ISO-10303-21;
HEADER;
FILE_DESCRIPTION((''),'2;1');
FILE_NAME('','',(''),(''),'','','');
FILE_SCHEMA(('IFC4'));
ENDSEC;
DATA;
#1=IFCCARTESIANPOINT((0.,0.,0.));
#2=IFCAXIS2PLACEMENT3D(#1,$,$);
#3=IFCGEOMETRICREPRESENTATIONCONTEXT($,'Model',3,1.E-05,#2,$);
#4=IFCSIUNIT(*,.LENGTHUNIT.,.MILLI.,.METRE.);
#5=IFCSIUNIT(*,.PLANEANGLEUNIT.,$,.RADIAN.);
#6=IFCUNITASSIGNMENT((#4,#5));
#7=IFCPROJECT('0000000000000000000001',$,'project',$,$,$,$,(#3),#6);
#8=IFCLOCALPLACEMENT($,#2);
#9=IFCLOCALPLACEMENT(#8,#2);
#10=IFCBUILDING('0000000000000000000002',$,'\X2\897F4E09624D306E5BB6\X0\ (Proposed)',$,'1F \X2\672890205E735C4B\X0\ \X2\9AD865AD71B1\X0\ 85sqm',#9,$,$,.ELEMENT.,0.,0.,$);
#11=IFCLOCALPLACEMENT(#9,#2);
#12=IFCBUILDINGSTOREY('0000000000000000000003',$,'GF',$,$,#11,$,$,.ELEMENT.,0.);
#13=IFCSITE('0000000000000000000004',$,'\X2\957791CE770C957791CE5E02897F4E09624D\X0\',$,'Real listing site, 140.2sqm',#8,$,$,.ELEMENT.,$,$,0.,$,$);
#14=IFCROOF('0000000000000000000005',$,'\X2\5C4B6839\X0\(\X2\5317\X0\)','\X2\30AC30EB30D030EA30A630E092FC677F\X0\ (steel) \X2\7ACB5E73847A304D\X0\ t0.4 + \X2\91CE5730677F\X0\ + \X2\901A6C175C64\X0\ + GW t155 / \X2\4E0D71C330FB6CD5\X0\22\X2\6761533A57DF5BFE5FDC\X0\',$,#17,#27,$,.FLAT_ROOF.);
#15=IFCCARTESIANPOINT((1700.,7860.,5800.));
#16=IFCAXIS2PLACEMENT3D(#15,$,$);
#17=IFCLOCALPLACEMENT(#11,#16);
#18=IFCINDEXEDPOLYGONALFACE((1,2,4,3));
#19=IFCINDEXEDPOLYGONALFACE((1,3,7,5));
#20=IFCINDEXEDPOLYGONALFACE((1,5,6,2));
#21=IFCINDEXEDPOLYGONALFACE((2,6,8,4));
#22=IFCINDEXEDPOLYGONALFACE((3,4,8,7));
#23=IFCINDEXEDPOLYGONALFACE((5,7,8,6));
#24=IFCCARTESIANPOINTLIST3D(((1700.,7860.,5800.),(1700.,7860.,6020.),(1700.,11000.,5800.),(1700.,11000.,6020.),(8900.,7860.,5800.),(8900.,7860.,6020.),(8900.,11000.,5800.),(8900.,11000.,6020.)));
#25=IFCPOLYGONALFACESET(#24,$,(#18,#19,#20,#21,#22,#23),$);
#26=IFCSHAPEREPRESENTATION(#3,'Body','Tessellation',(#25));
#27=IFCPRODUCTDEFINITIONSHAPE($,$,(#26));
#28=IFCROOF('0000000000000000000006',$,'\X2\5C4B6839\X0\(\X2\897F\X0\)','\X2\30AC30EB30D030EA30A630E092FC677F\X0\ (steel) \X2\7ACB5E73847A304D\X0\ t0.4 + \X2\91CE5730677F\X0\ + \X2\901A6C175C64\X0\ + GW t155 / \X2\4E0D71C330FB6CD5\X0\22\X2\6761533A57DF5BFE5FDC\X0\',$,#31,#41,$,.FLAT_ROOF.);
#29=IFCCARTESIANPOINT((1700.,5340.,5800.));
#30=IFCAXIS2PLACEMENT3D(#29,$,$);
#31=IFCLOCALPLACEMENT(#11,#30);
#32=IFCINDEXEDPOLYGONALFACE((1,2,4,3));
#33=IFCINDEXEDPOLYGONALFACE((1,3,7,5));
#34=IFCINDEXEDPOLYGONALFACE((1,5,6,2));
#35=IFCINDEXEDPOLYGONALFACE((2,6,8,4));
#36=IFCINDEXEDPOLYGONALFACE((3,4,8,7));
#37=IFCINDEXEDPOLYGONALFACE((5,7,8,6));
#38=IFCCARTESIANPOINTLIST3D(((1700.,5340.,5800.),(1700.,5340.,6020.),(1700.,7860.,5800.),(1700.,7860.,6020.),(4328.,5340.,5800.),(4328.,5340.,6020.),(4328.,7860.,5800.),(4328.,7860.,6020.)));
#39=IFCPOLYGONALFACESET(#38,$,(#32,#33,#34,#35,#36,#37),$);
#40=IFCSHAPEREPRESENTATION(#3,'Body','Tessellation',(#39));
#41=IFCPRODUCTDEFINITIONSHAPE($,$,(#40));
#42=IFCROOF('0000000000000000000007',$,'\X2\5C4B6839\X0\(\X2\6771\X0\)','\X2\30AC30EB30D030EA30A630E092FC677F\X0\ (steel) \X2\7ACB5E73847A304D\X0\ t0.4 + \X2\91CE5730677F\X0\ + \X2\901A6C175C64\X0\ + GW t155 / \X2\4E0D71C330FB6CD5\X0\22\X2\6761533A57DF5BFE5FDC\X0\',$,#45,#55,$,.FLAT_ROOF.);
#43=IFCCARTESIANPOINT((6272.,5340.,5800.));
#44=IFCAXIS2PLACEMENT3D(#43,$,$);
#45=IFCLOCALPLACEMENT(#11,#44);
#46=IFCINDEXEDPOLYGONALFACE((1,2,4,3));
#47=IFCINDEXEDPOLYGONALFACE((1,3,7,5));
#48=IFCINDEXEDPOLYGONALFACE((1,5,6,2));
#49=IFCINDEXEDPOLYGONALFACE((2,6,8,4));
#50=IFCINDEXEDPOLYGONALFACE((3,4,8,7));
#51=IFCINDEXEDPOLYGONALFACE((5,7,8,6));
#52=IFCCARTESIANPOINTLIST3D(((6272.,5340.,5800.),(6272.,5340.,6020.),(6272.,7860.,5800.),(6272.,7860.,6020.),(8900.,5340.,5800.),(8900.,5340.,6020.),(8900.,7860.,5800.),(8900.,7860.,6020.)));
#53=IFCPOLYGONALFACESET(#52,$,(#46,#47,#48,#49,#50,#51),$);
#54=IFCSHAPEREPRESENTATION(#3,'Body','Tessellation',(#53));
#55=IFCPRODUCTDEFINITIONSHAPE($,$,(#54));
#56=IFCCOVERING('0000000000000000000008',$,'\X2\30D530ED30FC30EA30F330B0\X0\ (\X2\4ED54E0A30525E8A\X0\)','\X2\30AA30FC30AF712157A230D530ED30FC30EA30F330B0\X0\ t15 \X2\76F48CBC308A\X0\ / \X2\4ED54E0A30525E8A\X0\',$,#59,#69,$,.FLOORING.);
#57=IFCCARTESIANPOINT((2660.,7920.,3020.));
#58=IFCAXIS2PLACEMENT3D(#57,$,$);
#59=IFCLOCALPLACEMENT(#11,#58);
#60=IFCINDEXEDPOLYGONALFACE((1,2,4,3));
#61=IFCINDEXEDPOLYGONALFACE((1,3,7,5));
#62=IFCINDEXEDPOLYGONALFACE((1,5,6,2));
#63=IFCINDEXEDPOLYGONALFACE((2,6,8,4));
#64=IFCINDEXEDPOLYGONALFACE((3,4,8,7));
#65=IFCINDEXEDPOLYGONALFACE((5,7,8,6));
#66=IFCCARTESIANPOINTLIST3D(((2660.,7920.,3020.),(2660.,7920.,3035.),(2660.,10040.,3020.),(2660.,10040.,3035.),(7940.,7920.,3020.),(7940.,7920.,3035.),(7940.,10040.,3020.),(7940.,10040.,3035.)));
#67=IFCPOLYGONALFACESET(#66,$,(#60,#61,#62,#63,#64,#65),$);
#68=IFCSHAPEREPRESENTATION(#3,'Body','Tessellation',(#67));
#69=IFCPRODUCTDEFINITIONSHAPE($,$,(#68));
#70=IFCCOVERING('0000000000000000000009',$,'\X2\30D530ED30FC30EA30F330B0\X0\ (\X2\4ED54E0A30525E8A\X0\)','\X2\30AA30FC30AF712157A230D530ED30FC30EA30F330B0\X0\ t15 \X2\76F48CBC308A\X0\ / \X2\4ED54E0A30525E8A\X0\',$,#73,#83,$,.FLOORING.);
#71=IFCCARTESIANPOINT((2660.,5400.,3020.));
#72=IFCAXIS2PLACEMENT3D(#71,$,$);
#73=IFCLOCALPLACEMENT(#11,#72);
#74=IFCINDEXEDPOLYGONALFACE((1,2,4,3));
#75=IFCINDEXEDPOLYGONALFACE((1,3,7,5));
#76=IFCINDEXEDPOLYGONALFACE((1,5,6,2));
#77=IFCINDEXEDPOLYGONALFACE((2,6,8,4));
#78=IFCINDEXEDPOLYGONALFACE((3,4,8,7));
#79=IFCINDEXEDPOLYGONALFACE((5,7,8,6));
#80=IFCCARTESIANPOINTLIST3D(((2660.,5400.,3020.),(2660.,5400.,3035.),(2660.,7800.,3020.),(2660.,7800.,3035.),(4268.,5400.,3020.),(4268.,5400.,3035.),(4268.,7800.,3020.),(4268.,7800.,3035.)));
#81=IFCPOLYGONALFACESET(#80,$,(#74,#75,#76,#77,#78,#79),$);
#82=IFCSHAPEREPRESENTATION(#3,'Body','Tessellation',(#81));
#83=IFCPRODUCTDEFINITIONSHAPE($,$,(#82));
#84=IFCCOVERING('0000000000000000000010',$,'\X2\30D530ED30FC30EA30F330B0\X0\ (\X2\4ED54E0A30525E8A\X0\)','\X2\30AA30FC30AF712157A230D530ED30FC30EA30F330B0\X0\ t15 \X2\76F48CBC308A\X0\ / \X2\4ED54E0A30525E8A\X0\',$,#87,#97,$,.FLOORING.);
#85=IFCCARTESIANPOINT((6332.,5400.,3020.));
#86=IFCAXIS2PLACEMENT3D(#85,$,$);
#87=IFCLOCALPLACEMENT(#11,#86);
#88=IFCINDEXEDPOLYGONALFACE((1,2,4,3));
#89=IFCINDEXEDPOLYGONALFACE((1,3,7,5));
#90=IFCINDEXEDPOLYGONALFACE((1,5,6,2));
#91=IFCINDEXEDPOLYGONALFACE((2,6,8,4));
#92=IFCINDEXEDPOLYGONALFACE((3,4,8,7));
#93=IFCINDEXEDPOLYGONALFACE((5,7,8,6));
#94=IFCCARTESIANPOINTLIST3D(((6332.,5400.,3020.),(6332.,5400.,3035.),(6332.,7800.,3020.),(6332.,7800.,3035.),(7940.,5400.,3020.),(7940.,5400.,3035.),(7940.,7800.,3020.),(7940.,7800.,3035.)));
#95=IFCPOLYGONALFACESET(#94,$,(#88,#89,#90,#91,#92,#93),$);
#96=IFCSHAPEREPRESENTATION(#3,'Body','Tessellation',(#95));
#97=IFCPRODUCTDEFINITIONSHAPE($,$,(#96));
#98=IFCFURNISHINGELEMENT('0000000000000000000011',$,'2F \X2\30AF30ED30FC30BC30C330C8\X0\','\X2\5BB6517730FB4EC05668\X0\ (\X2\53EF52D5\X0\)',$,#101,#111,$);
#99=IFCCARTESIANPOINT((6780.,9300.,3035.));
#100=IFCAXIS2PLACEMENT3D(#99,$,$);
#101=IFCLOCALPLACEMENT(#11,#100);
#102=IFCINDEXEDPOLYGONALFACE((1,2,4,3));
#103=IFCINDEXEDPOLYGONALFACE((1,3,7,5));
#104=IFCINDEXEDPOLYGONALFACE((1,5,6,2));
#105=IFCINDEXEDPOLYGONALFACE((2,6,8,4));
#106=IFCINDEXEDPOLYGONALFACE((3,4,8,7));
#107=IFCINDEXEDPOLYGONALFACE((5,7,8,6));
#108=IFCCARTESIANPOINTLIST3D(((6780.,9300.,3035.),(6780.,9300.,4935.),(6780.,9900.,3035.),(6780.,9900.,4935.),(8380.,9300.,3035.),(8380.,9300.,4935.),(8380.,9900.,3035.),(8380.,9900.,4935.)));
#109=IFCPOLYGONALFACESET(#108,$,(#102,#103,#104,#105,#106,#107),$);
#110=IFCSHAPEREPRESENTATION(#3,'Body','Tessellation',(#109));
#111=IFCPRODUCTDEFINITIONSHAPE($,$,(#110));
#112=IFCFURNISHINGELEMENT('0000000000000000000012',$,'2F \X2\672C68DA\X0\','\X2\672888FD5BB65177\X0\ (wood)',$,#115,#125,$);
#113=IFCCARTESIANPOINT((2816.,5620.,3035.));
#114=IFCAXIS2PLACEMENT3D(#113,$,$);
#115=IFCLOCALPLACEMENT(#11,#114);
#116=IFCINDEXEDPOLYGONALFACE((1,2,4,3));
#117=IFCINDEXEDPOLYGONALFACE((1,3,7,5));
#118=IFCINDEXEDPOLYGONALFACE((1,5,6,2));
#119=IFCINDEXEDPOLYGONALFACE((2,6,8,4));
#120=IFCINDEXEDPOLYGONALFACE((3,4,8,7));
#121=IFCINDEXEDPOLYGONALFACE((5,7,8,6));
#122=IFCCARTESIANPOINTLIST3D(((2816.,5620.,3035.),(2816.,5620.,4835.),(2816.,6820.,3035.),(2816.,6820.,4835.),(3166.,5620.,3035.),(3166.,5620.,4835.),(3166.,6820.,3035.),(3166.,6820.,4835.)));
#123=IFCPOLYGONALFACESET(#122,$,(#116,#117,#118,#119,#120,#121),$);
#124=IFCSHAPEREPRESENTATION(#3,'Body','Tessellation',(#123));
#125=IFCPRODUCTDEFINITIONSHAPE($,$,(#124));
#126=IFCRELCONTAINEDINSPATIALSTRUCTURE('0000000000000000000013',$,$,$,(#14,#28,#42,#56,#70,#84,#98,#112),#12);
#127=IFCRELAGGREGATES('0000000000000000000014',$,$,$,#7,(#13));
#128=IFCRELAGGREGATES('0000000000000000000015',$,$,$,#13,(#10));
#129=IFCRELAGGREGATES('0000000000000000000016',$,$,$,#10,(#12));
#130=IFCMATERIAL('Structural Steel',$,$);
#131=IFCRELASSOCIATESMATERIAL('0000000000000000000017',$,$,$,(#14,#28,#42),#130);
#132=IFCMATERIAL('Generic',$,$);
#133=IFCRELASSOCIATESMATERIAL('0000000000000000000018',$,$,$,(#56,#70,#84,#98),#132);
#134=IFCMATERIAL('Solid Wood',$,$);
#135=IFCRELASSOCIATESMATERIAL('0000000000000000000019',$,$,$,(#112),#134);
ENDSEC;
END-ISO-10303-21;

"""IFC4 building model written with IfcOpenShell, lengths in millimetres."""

from ifc_helpers import new_model, si_unit, frame, frame_2d, origin, place, context, project, spatial, rectangle, extrude, material, element, save


model = new_model("IFC4")

# Units and contexts
model_context = context("Model", 3, precision=1e-05, world=origin())
ifc_project = project(units=[si_unit("LENGTHUNIT", "METRE", prefix="MILLI"), si_unit("PLANEANGLEUNIT", "RADIAN")], contexts=[model_context])

# Site, building, storey
site_placement = place(None, origin())
site = spatial("IfcSite", under=ifc_project, at=site_placement, Name="長野県長野市西三才", ObjectType="Real listing site, 140.2sqm", CompositionType="ELEMENT", RefElevation=0.0)
building_placement = place(site_placement, origin())
building = spatial("IfcBuilding", under=site, at=building_placement, Name="西三才の家 (Proposed)", ObjectType="1F 木造平屋 高断熱 85sqm", CompositionType="ELEMENT", ElevationOfRefHeight=0.0, ElevationOfTerrain=0.0)
storey_placement = place(building_placement, origin())
storey = spatial("IfcBuildingStorey", under=building, at=storey_placement, Name="GF", CompositionType="ELEMENT", Elevation=0.0)

# Shared definitions
ifc_material_1 = material(Name="Solid Wood")

# Shared definitions
ifc_material_2 = material(Name="Generic")

# Roofs
ifc_material_3 = material(Name="Structural Steel")
for number, where, name in (
    (1, (1700.0, 7860.0, 5800.0), "屋根(北)"),
):
    element("IfcRoof", number, at=place(storey_placement, frame(where)), inside=storey, material=ifc_material_3, Name=name, Description="ガルバリウム鋼板 (steel) 立平葺き t0.4 + 野地板 + 通気層 + GW t155 / 不燃・法22条区域対応", PredefinedType="FLAT_ROOF", context=model_context, shape_type="SweptSolid", body=[
        extrude(rectangle(XDim=7200.0, YDim=3140.0, at=frame_2d((3600.0, 1570.0))), frame((1700.0, 7860.0, 5800.0)), (0.0, 0.0, 1.0), 220.0),
    ])
roof_1_placement = place(storey_placement, frame((1700.0, 5340.0, 5800.0)))
element("IfcRoof", 2, at=roof_1_placement, inside=storey, material=ifc_material_3, Name="屋根(西)", Description="ガルバリウム鋼板 (steel) 立平葺き t0.4 + 野地板 + 通気層 + GW t155 / 不燃・法22条区域対応", PredefinedType="FLAT_ROOF", context=model_context, shape_type="SweptSolid", body=[
    extrude(rectangle(XDim=2628.0, YDim=2520.0, at=frame_2d((1314.0, 1260.0))), frame((1700.0, 5340.0, 5800.0)), (0.0, 0.0, 1.0), 220.0),
])
roof_2_placement = place(storey_placement, frame((6272.0, 5340.0, 5800.0)))
element("IfcRoof", 3, at=roof_2_placement, inside=storey, material=ifc_material_3, Name="屋根(東)", Description="ガルバリウム鋼板 (steel) 立平葺き t0.4 + 野地板 + 通気層 + GW t155 / 不燃・法22条区域対応", PredefinedType="FLAT_ROOF", context=model_context, shape_type="SweptSolid", body=[
    extrude(rectangle(XDim=2628.0, YDim=2520.0, at=frame_2d((1314.0, 1260.0))), frame((6272.0, 5340.0, 5800.0)), (0.0, 0.0, 1.0), 220.0),
])

# Coverings
covering_1_placement = place(storey_placement, frame((2660.0, 7920.0, 3020.0)))
element("IfcCovering", 4, at=covering_1_placement, inside=storey, material=ifc_material_2, Name="フローリング (仕上げ床)", Description="オーク無垢フローリング t15 直貼り / 仕上げ床", PredefinedType="FLOORING", context=model_context, shape_type="SweptSolid", body=[
    extrude(rectangle(XDim=5280.0, YDim=2120.0, at=frame_2d((2640.0, 1060.0))), frame((2660.0, 7920.0, 3020.0)), (0.0, 0.0, 1.0), 15.0),
])
covering_2_placement = place(storey_placement, frame((2660.0, 5400.0, 3020.0)))
element("IfcCovering", 5, at=covering_2_placement, inside=storey, material=ifc_material_2, Name="フローリング (仕上げ床)", Description="オーク無垢フローリング t15 直貼り / 仕上げ床", PredefinedType="FLOORING", context=model_context, shape_type="SweptSolid", body=[
    extrude(rectangle(XDim=1608.0, YDim=2400.0, at=frame_2d((804.0, 1200.0))), frame((2660.0, 5400.0, 3020.0)), (0.0, 0.0, 1.0), 15.0),
])
covering_3_placement = place(storey_placement, frame((6332.0, 5400.0, 3020.0)))
element("IfcCovering", 6, at=covering_3_placement, inside=storey, material=ifc_material_2, Name="フローリング (仕上げ床)", Description="オーク無垢フローリング t15 直貼り / 仕上げ床", PredefinedType="FLOORING", context=model_context, shape_type="SweptSolid", body=[
    extrude(rectangle(XDim=1608.0, YDim=2400.0, at=frame_2d((804.0, 1200.0))), frame((6332.0, 5400.0, 3020.0)), (0.0, 0.0, 1.0), 15.0),
])

# Furnishing elements
furnishing_1_placement = place(storey_placement, frame((6780.0, 9300.0, 3035.0)))
element("IfcFurnishingElement", 7, at=furnishing_1_placement, inside=storey, material=ifc_material_2, Name="2F クローゼット", Description="家具・什器 (可動)", context=model_context, shape_type="SweptSolid", body=[
    extrude(rectangle(XDim=1600.0, YDim=600.0, at=frame_2d((800.0, 300.0))), frame((6780.0, 9300.0, 3035.0)), (0.0, 0.0, 1.0), 1900.0),
])
furnishing_2_placement = place(storey_placement, frame((2816.0, 5620.0, 3035.0)))
element("IfcFurnishingElement", 8, at=furnishing_2_placement, inside=storey, material=ifc_material_1, Name="2F 本棚", Description="木製家具 (wood)", context=model_context, shape_type="SweptSolid", body=[
    extrude(rectangle(XDim=350.0, YDim=1200.0, at=frame_2d((175.0, 600.0))), frame((2816.0, 5620.0, 3035.0)), (0.0, 0.0, 1.0), 1800.0),
])

save(model, "model.ifc")
